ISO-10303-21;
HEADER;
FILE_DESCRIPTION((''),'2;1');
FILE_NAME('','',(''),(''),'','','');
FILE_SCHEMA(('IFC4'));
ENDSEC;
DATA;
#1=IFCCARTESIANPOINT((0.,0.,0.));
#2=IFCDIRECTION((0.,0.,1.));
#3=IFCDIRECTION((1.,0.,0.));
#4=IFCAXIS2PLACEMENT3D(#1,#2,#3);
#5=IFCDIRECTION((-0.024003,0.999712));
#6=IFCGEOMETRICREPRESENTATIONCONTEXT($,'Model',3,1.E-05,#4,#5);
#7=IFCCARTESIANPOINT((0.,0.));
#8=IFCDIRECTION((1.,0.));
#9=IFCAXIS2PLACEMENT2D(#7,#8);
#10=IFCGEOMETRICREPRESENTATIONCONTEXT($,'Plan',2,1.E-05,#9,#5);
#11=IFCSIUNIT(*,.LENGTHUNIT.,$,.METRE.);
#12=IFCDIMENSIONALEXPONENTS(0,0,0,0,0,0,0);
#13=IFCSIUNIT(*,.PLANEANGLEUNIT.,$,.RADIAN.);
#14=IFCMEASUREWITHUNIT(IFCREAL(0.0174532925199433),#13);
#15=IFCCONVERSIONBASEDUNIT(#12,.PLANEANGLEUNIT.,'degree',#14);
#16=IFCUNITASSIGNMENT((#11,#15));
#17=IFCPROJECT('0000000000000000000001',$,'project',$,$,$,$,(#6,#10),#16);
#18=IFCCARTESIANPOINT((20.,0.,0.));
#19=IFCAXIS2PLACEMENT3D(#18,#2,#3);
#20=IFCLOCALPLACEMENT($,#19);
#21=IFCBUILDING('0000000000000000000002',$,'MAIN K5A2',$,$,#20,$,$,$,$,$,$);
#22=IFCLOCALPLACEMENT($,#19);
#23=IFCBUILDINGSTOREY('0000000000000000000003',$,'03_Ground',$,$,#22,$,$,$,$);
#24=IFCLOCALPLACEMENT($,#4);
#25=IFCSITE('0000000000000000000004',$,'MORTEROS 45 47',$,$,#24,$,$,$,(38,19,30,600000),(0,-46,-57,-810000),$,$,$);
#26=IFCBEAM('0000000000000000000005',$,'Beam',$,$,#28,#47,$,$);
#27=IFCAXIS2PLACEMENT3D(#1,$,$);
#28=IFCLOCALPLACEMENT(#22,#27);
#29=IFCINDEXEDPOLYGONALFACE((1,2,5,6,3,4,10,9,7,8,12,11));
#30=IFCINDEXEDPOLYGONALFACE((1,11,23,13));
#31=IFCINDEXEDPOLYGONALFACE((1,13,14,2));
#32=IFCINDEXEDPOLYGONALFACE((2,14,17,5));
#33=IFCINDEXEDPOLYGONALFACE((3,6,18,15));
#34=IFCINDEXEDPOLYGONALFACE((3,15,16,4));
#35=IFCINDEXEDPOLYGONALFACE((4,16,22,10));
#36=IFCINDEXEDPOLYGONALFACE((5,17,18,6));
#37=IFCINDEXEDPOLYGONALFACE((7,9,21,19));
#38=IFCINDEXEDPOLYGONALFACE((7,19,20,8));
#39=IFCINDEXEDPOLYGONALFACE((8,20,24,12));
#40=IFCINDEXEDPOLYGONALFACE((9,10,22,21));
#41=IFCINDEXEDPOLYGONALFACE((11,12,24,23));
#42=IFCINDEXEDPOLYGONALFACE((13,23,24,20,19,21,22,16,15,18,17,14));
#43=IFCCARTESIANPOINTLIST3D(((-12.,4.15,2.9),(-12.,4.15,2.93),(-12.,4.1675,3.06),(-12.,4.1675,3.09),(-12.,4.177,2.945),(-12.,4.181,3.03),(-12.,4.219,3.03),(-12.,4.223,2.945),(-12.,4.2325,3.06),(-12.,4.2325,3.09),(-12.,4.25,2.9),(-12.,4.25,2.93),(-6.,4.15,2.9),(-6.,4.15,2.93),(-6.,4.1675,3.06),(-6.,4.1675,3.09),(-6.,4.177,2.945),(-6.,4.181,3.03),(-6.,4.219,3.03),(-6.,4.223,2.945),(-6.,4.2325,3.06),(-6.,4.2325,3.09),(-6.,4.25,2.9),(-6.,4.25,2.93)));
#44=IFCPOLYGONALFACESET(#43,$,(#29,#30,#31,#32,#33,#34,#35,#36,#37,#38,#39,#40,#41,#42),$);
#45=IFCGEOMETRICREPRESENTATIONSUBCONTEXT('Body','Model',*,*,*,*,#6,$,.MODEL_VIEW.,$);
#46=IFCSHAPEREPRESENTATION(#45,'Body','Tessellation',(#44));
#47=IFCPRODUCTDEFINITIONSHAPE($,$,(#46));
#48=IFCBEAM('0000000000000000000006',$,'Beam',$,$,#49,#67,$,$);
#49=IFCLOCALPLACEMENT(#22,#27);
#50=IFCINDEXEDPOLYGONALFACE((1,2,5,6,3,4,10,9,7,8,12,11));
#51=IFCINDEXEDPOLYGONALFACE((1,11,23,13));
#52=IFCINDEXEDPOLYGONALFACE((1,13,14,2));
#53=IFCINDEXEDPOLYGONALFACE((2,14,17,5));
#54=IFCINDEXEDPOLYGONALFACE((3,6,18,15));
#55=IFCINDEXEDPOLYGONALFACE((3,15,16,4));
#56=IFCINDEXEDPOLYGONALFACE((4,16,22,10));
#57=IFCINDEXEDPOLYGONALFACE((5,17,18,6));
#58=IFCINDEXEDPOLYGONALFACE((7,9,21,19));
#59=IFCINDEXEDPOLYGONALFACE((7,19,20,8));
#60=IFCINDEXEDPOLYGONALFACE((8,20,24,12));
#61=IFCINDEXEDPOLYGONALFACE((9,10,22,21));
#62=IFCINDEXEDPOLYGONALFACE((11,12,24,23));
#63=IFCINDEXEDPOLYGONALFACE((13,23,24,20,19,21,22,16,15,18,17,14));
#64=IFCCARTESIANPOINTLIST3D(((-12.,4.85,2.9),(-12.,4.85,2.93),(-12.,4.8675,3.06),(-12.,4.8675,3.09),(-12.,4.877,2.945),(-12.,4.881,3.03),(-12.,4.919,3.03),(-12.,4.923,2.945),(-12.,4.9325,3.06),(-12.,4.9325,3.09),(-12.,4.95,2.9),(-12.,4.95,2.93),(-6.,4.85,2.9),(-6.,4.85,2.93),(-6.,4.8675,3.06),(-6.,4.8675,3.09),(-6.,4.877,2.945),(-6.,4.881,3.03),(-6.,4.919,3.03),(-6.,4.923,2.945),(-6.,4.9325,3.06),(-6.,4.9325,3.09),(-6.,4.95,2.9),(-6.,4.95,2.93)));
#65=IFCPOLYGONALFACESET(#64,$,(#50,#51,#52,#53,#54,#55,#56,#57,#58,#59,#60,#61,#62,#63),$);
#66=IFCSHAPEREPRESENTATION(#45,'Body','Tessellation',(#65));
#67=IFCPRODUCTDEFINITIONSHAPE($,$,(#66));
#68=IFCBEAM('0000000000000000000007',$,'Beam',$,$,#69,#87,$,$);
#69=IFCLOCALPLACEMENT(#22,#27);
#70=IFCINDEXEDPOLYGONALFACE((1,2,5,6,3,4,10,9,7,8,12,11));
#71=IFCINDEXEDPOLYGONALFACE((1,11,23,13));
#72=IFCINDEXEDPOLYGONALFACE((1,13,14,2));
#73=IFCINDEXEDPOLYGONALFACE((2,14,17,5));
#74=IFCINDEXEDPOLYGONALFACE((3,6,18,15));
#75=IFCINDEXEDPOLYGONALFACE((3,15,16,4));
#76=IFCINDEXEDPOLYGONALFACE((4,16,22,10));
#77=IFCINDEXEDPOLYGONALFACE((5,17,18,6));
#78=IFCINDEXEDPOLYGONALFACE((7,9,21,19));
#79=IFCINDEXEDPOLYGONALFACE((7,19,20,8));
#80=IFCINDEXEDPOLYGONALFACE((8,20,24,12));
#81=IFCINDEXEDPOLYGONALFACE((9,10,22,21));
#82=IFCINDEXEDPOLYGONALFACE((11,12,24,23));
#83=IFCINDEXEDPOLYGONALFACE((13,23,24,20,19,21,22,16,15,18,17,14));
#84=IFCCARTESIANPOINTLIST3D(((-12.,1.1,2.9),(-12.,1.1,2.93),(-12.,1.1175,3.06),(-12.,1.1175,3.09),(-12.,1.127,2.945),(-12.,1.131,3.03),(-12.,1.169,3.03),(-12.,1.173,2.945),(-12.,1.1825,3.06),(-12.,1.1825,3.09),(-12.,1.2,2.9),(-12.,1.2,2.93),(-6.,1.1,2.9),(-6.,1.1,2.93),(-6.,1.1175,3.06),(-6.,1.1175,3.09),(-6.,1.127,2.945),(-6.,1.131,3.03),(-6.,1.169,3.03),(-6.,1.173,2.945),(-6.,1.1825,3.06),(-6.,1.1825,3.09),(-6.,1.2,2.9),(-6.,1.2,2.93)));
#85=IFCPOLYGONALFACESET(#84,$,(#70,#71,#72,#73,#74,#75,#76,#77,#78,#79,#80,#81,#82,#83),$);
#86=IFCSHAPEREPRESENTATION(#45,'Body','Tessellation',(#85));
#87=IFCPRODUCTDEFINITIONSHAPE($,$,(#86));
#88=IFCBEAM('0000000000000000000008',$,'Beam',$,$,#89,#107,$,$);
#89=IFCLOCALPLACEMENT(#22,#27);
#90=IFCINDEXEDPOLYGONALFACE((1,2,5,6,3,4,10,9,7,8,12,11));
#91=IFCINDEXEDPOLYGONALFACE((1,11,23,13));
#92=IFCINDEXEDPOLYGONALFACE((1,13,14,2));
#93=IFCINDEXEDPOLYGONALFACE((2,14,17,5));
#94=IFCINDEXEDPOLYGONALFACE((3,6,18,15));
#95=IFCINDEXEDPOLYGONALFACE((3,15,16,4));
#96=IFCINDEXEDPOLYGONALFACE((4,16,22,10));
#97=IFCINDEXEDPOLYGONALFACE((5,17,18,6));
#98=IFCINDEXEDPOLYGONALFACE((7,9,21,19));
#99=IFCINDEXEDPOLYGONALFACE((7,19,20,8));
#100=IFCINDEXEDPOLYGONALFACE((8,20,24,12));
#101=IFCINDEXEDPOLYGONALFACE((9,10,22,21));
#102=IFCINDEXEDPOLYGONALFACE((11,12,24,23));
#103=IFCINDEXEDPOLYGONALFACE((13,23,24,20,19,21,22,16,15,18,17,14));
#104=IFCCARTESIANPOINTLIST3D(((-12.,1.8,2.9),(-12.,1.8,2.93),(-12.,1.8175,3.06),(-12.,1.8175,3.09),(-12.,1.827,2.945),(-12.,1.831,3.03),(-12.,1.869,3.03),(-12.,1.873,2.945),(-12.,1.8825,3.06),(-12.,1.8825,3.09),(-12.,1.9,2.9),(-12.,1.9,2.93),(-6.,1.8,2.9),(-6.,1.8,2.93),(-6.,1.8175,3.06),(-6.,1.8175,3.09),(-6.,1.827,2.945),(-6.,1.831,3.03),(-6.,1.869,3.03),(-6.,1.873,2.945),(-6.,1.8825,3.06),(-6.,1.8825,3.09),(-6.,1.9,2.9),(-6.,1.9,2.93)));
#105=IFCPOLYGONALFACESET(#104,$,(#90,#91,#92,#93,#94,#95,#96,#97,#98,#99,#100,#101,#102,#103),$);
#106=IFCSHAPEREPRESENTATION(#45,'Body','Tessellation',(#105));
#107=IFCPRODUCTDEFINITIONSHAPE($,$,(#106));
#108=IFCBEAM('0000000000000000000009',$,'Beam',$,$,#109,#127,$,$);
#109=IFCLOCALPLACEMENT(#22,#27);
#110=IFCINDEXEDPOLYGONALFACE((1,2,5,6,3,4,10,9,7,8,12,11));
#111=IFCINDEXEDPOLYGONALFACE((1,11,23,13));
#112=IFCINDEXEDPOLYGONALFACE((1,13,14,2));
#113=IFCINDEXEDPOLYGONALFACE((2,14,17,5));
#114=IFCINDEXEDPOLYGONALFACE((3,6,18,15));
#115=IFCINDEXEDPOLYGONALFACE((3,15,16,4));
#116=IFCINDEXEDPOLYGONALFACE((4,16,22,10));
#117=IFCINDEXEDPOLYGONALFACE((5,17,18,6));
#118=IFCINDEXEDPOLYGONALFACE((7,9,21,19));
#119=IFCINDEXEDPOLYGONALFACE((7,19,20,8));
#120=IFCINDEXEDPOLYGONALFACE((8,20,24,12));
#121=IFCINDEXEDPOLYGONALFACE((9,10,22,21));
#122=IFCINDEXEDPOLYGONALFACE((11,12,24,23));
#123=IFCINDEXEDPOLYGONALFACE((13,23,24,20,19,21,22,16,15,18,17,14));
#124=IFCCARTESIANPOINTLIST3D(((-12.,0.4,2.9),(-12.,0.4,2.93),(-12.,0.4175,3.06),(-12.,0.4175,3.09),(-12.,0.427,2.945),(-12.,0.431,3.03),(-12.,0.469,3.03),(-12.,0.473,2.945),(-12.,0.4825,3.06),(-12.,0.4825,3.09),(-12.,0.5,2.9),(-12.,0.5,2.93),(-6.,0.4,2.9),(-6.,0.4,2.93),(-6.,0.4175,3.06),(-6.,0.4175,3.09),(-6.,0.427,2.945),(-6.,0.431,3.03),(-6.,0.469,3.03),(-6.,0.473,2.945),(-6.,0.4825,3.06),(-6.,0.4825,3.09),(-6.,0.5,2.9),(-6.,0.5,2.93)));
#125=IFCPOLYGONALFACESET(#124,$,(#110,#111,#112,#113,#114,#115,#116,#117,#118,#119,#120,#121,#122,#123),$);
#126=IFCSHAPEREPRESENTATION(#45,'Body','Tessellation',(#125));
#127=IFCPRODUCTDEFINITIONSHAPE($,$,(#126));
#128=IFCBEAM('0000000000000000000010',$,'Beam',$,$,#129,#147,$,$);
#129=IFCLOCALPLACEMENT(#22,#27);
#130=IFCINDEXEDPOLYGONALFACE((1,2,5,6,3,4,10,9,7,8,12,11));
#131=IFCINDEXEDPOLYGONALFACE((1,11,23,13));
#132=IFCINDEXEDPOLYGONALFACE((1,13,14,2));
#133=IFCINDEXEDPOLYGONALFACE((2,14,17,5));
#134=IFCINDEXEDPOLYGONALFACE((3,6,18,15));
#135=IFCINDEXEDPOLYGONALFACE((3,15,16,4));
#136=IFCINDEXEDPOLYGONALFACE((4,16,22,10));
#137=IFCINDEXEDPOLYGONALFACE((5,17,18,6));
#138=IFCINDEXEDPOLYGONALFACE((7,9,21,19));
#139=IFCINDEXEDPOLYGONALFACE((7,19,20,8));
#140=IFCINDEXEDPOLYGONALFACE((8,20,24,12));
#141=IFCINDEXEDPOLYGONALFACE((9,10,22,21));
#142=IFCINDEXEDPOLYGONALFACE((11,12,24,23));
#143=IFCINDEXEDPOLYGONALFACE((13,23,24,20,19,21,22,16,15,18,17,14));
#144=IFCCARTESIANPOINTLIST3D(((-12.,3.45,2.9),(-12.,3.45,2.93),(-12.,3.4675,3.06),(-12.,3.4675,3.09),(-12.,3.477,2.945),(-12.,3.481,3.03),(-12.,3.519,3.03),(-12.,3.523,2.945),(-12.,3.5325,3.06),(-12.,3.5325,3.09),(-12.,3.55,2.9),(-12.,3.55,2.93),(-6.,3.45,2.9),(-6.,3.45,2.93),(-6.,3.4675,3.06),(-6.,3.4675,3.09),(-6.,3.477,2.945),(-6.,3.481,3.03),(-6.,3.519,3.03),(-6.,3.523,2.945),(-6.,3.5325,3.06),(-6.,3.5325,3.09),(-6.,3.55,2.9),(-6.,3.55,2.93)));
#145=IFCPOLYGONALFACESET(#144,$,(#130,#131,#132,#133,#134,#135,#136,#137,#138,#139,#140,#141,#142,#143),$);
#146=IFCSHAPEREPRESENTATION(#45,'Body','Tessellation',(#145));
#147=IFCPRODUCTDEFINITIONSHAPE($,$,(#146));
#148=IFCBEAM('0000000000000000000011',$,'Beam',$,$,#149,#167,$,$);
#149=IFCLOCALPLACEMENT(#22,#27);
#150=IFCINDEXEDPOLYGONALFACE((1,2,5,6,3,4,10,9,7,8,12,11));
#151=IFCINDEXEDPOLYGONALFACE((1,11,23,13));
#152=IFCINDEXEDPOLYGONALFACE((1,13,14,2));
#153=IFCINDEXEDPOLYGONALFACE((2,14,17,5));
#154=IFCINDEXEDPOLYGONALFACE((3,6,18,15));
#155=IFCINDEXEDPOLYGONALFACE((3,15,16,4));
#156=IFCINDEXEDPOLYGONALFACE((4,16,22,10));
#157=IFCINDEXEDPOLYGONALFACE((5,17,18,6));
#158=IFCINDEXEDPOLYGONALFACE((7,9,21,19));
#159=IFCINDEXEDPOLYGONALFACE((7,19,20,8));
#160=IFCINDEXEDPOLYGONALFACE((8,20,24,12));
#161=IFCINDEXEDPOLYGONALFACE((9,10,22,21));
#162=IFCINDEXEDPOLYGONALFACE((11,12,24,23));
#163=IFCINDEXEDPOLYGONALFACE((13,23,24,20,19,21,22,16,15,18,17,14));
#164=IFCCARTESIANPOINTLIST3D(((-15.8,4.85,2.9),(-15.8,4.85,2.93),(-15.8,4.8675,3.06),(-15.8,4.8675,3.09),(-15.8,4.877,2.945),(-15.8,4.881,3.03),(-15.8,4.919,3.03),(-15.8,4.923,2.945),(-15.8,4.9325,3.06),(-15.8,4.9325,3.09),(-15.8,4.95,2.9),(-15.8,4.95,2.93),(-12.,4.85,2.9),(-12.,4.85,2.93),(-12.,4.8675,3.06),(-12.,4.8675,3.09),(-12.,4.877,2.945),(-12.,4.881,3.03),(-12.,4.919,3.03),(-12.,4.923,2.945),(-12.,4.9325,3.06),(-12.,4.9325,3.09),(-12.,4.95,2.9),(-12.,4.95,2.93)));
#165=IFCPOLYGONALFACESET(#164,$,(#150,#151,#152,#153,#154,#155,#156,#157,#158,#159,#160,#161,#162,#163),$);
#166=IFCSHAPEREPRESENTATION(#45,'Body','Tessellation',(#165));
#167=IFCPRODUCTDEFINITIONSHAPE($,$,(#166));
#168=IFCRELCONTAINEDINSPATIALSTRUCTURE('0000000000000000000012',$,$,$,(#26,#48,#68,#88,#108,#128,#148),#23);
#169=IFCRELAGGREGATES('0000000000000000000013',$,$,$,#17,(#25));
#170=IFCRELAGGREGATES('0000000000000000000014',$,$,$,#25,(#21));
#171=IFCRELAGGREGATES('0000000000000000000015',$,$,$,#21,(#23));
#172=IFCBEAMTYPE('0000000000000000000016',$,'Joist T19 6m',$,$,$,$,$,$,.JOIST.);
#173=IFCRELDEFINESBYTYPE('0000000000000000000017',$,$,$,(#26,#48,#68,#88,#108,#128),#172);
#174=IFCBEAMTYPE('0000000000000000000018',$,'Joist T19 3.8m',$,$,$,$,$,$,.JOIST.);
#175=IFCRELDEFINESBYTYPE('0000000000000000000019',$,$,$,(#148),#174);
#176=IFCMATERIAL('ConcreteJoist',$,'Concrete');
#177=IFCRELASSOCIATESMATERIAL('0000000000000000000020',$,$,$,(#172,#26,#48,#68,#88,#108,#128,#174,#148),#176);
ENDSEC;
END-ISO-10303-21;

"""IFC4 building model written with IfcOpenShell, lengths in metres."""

from ifc_helpers import new_model, entity, si_unit, converted_unit, direction, frame, origin_with_axes, origin_2d_with_axis, place, context, subcontext, project, spatial, indexed_curve, outline, extrude, material, material_profile, profile_set, profile_usage, type_object, element, save


model = new_model("IFC4")

# Units and contexts
model_context = context("Model", 3, precision=1e-05, world=origin_with_axes(), true_north=direction((-0.024003, 0.999712)))
plan_context = context("Plan", 2, precision=1e-05, world=origin_2d_with_axis(), true_north=direction((-0.024003, 0.999712)))
body_context_1 = subcontext(model_context, "Body", "Model", "MODEL_VIEW")
ifc_project = project(units=[si_unit("LENGTHUNIT", "METRE"), converted_unit("PLANEANGLEUNIT", "degree", entity("IfcReal", 0.0174532925199433), si_unit("PLANEANGLEUNIT", "RADIAN"), dimensions=[0, 0, 0, 0, 0, 0, 0])], contexts=[model_context, plan_context])

# Site, building, storey
site_placement = place(None, origin_with_axes())
site = spatial("IfcSite", under=ifc_project, at=site_placement, Name="MORTEROS 45 47", RefLatitude=(38, 19, 30, 600000), RefLongitude=(0, -46, -57, -810000))
building_placement = place(None, frame((20.0, 0.0, 0.0), z_axis=(0.0, 0.0, 1.0), x_axis=(1.0, 0.0, 0.0)))
building = spatial("IfcBuilding", under=site, at=building_placement, Name="MAIN K5A2")
storey_placement = place(None, frame((20.0, 0.0, 0.0), z_axis=(0.0, 0.0, 1.0), x_axis=(1.0, 0.0, 0.0)))
storey = spatial("IfcBuildingStorey", under=building, at=storey_placement, Name="03_Ground")

# Beams
ifc_material = material(Name="ConcreteJoist", Category="Concrete")
ifc_material_profile_1 = material_profile(ifc_material, outline(indexed_curve([(0.019, 0.13), (0.023, 0.045), (0.05, 0.03), (0.05, 0.0), (-0.05, 0.0), (-0.05, 0.03), (-0.023, 0.045), (-0.019, 0.13), (-0.0325, 0.16), (-0.0325, 0.19), (0.0325, 0.19), (0.0325, 0.16), (0.019, 0.13)])))
ifc_profile_set_1 = profile_set([ifc_material_profile_1], Name="JoistmaterialProfile")
ifc_profile_usage_1 = profile_usage(ifc_profile_set_1)
beam_type_1 = type_object("IfcBeamType", Name="Joist T19 6m", PredefinedType="JOIST", material=ifc_profile_set_1)
beam_1_placement = place(None, frame((8.0, 4.2, 2.9), z_axis=(1.0, 0.0, 0.0), x_axis=(0.0, 1.0, 0.0)))
element("IfcBeam", 1, at=beam_1_placement, inside=storey, type_object=beam_type_1, material=ifc_profile_usage_1, Name="Beam", context=body_context_1, shape_type="SweptSolid", body=[
    extrude(outline(indexed_curve([(0.019, 0.13), (0.023, 0.045), (0.05, 0.03), (0.05, 0.0), (-0.05, 0.0), (-0.05, 0.03), (-0.023, 0.045), (-0.019, 0.13), (-0.0325, 0.16), (-0.0325, 0.19), (0.0325, 0.19), (0.0325, 0.16), (0.019, 0.13)])), origin_with_axes(), (0.0, 0.0, 1.0), 6.0),
])
ifc_profile_usage_2 = profile_usage(ifc_profile_set_1)
beam_2_placement = place(None, frame((8.0, 4.9, 2.9), z_axis=(1.0, 0.0, 0.0), x_axis=(0.0, 1.0, 0.0)))
element("IfcBeam", 2, at=beam_2_placement, inside=storey, type_object=beam_type_1, material=ifc_profile_usage_2, Name="Beam", context=body_context_1, shape_type="SweptSolid", body=[
    extrude(outline(indexed_curve([(0.019, 0.13), (0.023, 0.045), (0.05, 0.03), (0.05, 0.0), (-0.05, 0.0), (-0.05, 0.03), (-0.023, 0.045), (-0.019, 0.13), (-0.0325, 0.16), (-0.0325, 0.19), (0.0325, 0.19), (0.0325, 0.16), (0.019, 0.13)])), origin_with_axes(), (0.0, 0.0, 1.0), 6.0),
])
ifc_profile_usage_3 = profile_usage(ifc_profile_set_1)
beam_3_placement = place(None, frame((8.0, 1.15, 2.9), z_axis=(1.0, 0.0, 0.0), x_axis=(0.0, 1.0, 0.0)))
element("IfcBeam", 3, at=beam_3_placement, inside=storey, type_object=beam_type_1, material=ifc_profile_usage_3, Name="Beam", context=body_context_1, shape_type="SweptSolid", body=[
    extrude(outline(indexed_curve([(0.019, 0.13), (0.023, 0.045), (0.05, 0.03), (0.05, 0.0), (-0.05, 0.0), (-0.05, 0.03), (-0.023, 0.045), (-0.019, 0.13), (-0.0325, 0.16), (-0.0325, 0.19), (0.0325, 0.19), (0.0325, 0.16), (0.019, 0.13)])), origin_with_axes(), (0.0, 0.0, 1.0), 6.0),
])
ifc_profile_usage_4 = profile_usage(ifc_profile_set_1)
beam_4_placement = place(None, frame((8.0, 1.85, 2.9), z_axis=(1.0, 0.0, 0.0), x_axis=(0.0, 1.0, 0.0)))
element("IfcBeam", 4, at=beam_4_placement, inside=storey, type_object=beam_type_1, material=ifc_profile_usage_4, Name="Beam", context=body_context_1, shape_type="SweptSolid", body=[
    extrude(outline(indexed_curve([(0.019, 0.13), (0.023, 0.045), (0.05, 0.03), (0.05, 0.0), (-0.05, 0.0), (-0.05, 0.03), (-0.023, 0.045), (-0.019, 0.13), (-0.0325, 0.16), (-0.0325, 0.19), (0.0325, 0.19), (0.0325, 0.16), (0.019, 0.13)])), origin_with_axes(), (0.0, 0.0, 1.0), 6.0),
])
ifc_profile_usage_5 = profile_usage(ifc_profile_set_1)
beam_5_placement = place(None, frame((8.0, 0.45, 2.9), z_axis=(1.0, 0.0, 0.0), x_axis=(0.0, 1.0, 0.0)))
element("IfcBeam", 5, at=beam_5_placement, inside=storey, type_object=beam_type_1, material=ifc_profile_usage_5, Name="Beam", context=body_context_1, shape_type="SweptSolid", body=[
    extrude(outline(indexed_curve([(0.019, 0.13), (0.023, 0.045), (0.05, 0.03), (0.05, 0.0), (-0.05, 0.0), (-0.05, 0.03), (-0.023, 0.045), (-0.019, 0.13), (-0.0325, 0.16), (-0.0325, 0.19), (0.0325, 0.19), (0.0325, 0.16), (0.019, 0.13)])), origin_with_axes(), (0.0, 0.0, 1.0), 6.0),
])
ifc_profile_usage_6 = profile_usage(ifc_profile_set_1)
beam_6_placement = place(None, frame((8.0, 3.5, 2.9), z_axis=(1.0, 0.0, 0.0), x_axis=(0.0, 1.0, 0.0)))
element("IfcBeam", 6, at=beam_6_placement, inside=storey, type_object=beam_type_1, material=ifc_profile_usage_6, Name="Beam", context=body_context_1, shape_type="SweptSolid", body=[
    extrude(outline(indexed_curve([(0.019, 0.13), (0.023, 0.045), (0.05, 0.03), (0.05, 0.0), (-0.05, 0.0), (-0.05, 0.03), (-0.023, 0.045), (-0.019, 0.13), (-0.0325, 0.16), (-0.0325, 0.19), (0.0325, 0.19), (0.0325, 0.16), (0.019, 0.13)])), origin_with_axes(), (0.0, 0.0, 1.0), 6.0),
])
ifc_material_profile_2 = material_profile(ifc_material, outline(indexed_curve([(0.019, 0.13), (0.023, 0.045), (0.05, 0.03), (0.05, 0.0), (-0.05, 0.0), (-0.05, 0.03), (-0.023, 0.045), (-0.019, 0.13), (-0.0325, 0.16), (-0.0325, 0.19), (0.0325, 0.19), (0.0325, 0.16), (0.019, 0.13)])))
ifc_profile_set_2 = profile_set([ifc_material_profile_2], Name="JoistMaterialProfileSet")
ifc_profile_usage_7 = profile_usage(ifc_profile_set_2)
ifc_material_profile_3 = material_profile(ifc_material, outline(indexed_curve([(0.019, 0.13), (0.023, 0.045), (0.05, 0.03), (0.05, 0.0), (-0.05, 0.0), (-0.05, 0.03), (-0.023, 0.045), (-0.019, 0.13), (-0.0325, 0.16), (-0.0325, 0.19), (0.0325, 0.19), (0.0325, 0.16), (0.019, 0.13)])))
ifc_profile_set_3 = profile_set([ifc_material_profile_3], Name="JoistMaterialProfileSet")
beam_type_2 = type_object("IfcBeamType", Name="Joist T19 3.8m", PredefinedType="JOIST", material=ifc_profile_set_3)
beam_7_placement = place(None, frame((4.2, 4.9, 2.9), z_axis=(1.0, 0.0, 0.0), x_axis=(0.0, 1.0, 0.0)))
element("IfcBeam", 7, at=beam_7_placement, inside=storey, type_object=beam_type_2, material=ifc_profile_usage_7, Name="Beam", context=body_context_1, shape_type="SweptSolid", body=[
    extrude(outline(indexed_curve([(0.019, 0.13), (0.023, 0.045), (0.05, 0.03), (0.05, 0.0), (-0.05, 0.0), (-0.05, 0.03), (-0.023, 0.045), (-0.019, 0.13), (-0.0325, 0.16), (-0.0325, 0.19), (0.0325, 0.19), (0.0325, 0.16), (0.019, 0.13)])), origin_with_axes(), (0.0, 0.0, 1.0), 3.8),
])

save(model, "model.ifc")
